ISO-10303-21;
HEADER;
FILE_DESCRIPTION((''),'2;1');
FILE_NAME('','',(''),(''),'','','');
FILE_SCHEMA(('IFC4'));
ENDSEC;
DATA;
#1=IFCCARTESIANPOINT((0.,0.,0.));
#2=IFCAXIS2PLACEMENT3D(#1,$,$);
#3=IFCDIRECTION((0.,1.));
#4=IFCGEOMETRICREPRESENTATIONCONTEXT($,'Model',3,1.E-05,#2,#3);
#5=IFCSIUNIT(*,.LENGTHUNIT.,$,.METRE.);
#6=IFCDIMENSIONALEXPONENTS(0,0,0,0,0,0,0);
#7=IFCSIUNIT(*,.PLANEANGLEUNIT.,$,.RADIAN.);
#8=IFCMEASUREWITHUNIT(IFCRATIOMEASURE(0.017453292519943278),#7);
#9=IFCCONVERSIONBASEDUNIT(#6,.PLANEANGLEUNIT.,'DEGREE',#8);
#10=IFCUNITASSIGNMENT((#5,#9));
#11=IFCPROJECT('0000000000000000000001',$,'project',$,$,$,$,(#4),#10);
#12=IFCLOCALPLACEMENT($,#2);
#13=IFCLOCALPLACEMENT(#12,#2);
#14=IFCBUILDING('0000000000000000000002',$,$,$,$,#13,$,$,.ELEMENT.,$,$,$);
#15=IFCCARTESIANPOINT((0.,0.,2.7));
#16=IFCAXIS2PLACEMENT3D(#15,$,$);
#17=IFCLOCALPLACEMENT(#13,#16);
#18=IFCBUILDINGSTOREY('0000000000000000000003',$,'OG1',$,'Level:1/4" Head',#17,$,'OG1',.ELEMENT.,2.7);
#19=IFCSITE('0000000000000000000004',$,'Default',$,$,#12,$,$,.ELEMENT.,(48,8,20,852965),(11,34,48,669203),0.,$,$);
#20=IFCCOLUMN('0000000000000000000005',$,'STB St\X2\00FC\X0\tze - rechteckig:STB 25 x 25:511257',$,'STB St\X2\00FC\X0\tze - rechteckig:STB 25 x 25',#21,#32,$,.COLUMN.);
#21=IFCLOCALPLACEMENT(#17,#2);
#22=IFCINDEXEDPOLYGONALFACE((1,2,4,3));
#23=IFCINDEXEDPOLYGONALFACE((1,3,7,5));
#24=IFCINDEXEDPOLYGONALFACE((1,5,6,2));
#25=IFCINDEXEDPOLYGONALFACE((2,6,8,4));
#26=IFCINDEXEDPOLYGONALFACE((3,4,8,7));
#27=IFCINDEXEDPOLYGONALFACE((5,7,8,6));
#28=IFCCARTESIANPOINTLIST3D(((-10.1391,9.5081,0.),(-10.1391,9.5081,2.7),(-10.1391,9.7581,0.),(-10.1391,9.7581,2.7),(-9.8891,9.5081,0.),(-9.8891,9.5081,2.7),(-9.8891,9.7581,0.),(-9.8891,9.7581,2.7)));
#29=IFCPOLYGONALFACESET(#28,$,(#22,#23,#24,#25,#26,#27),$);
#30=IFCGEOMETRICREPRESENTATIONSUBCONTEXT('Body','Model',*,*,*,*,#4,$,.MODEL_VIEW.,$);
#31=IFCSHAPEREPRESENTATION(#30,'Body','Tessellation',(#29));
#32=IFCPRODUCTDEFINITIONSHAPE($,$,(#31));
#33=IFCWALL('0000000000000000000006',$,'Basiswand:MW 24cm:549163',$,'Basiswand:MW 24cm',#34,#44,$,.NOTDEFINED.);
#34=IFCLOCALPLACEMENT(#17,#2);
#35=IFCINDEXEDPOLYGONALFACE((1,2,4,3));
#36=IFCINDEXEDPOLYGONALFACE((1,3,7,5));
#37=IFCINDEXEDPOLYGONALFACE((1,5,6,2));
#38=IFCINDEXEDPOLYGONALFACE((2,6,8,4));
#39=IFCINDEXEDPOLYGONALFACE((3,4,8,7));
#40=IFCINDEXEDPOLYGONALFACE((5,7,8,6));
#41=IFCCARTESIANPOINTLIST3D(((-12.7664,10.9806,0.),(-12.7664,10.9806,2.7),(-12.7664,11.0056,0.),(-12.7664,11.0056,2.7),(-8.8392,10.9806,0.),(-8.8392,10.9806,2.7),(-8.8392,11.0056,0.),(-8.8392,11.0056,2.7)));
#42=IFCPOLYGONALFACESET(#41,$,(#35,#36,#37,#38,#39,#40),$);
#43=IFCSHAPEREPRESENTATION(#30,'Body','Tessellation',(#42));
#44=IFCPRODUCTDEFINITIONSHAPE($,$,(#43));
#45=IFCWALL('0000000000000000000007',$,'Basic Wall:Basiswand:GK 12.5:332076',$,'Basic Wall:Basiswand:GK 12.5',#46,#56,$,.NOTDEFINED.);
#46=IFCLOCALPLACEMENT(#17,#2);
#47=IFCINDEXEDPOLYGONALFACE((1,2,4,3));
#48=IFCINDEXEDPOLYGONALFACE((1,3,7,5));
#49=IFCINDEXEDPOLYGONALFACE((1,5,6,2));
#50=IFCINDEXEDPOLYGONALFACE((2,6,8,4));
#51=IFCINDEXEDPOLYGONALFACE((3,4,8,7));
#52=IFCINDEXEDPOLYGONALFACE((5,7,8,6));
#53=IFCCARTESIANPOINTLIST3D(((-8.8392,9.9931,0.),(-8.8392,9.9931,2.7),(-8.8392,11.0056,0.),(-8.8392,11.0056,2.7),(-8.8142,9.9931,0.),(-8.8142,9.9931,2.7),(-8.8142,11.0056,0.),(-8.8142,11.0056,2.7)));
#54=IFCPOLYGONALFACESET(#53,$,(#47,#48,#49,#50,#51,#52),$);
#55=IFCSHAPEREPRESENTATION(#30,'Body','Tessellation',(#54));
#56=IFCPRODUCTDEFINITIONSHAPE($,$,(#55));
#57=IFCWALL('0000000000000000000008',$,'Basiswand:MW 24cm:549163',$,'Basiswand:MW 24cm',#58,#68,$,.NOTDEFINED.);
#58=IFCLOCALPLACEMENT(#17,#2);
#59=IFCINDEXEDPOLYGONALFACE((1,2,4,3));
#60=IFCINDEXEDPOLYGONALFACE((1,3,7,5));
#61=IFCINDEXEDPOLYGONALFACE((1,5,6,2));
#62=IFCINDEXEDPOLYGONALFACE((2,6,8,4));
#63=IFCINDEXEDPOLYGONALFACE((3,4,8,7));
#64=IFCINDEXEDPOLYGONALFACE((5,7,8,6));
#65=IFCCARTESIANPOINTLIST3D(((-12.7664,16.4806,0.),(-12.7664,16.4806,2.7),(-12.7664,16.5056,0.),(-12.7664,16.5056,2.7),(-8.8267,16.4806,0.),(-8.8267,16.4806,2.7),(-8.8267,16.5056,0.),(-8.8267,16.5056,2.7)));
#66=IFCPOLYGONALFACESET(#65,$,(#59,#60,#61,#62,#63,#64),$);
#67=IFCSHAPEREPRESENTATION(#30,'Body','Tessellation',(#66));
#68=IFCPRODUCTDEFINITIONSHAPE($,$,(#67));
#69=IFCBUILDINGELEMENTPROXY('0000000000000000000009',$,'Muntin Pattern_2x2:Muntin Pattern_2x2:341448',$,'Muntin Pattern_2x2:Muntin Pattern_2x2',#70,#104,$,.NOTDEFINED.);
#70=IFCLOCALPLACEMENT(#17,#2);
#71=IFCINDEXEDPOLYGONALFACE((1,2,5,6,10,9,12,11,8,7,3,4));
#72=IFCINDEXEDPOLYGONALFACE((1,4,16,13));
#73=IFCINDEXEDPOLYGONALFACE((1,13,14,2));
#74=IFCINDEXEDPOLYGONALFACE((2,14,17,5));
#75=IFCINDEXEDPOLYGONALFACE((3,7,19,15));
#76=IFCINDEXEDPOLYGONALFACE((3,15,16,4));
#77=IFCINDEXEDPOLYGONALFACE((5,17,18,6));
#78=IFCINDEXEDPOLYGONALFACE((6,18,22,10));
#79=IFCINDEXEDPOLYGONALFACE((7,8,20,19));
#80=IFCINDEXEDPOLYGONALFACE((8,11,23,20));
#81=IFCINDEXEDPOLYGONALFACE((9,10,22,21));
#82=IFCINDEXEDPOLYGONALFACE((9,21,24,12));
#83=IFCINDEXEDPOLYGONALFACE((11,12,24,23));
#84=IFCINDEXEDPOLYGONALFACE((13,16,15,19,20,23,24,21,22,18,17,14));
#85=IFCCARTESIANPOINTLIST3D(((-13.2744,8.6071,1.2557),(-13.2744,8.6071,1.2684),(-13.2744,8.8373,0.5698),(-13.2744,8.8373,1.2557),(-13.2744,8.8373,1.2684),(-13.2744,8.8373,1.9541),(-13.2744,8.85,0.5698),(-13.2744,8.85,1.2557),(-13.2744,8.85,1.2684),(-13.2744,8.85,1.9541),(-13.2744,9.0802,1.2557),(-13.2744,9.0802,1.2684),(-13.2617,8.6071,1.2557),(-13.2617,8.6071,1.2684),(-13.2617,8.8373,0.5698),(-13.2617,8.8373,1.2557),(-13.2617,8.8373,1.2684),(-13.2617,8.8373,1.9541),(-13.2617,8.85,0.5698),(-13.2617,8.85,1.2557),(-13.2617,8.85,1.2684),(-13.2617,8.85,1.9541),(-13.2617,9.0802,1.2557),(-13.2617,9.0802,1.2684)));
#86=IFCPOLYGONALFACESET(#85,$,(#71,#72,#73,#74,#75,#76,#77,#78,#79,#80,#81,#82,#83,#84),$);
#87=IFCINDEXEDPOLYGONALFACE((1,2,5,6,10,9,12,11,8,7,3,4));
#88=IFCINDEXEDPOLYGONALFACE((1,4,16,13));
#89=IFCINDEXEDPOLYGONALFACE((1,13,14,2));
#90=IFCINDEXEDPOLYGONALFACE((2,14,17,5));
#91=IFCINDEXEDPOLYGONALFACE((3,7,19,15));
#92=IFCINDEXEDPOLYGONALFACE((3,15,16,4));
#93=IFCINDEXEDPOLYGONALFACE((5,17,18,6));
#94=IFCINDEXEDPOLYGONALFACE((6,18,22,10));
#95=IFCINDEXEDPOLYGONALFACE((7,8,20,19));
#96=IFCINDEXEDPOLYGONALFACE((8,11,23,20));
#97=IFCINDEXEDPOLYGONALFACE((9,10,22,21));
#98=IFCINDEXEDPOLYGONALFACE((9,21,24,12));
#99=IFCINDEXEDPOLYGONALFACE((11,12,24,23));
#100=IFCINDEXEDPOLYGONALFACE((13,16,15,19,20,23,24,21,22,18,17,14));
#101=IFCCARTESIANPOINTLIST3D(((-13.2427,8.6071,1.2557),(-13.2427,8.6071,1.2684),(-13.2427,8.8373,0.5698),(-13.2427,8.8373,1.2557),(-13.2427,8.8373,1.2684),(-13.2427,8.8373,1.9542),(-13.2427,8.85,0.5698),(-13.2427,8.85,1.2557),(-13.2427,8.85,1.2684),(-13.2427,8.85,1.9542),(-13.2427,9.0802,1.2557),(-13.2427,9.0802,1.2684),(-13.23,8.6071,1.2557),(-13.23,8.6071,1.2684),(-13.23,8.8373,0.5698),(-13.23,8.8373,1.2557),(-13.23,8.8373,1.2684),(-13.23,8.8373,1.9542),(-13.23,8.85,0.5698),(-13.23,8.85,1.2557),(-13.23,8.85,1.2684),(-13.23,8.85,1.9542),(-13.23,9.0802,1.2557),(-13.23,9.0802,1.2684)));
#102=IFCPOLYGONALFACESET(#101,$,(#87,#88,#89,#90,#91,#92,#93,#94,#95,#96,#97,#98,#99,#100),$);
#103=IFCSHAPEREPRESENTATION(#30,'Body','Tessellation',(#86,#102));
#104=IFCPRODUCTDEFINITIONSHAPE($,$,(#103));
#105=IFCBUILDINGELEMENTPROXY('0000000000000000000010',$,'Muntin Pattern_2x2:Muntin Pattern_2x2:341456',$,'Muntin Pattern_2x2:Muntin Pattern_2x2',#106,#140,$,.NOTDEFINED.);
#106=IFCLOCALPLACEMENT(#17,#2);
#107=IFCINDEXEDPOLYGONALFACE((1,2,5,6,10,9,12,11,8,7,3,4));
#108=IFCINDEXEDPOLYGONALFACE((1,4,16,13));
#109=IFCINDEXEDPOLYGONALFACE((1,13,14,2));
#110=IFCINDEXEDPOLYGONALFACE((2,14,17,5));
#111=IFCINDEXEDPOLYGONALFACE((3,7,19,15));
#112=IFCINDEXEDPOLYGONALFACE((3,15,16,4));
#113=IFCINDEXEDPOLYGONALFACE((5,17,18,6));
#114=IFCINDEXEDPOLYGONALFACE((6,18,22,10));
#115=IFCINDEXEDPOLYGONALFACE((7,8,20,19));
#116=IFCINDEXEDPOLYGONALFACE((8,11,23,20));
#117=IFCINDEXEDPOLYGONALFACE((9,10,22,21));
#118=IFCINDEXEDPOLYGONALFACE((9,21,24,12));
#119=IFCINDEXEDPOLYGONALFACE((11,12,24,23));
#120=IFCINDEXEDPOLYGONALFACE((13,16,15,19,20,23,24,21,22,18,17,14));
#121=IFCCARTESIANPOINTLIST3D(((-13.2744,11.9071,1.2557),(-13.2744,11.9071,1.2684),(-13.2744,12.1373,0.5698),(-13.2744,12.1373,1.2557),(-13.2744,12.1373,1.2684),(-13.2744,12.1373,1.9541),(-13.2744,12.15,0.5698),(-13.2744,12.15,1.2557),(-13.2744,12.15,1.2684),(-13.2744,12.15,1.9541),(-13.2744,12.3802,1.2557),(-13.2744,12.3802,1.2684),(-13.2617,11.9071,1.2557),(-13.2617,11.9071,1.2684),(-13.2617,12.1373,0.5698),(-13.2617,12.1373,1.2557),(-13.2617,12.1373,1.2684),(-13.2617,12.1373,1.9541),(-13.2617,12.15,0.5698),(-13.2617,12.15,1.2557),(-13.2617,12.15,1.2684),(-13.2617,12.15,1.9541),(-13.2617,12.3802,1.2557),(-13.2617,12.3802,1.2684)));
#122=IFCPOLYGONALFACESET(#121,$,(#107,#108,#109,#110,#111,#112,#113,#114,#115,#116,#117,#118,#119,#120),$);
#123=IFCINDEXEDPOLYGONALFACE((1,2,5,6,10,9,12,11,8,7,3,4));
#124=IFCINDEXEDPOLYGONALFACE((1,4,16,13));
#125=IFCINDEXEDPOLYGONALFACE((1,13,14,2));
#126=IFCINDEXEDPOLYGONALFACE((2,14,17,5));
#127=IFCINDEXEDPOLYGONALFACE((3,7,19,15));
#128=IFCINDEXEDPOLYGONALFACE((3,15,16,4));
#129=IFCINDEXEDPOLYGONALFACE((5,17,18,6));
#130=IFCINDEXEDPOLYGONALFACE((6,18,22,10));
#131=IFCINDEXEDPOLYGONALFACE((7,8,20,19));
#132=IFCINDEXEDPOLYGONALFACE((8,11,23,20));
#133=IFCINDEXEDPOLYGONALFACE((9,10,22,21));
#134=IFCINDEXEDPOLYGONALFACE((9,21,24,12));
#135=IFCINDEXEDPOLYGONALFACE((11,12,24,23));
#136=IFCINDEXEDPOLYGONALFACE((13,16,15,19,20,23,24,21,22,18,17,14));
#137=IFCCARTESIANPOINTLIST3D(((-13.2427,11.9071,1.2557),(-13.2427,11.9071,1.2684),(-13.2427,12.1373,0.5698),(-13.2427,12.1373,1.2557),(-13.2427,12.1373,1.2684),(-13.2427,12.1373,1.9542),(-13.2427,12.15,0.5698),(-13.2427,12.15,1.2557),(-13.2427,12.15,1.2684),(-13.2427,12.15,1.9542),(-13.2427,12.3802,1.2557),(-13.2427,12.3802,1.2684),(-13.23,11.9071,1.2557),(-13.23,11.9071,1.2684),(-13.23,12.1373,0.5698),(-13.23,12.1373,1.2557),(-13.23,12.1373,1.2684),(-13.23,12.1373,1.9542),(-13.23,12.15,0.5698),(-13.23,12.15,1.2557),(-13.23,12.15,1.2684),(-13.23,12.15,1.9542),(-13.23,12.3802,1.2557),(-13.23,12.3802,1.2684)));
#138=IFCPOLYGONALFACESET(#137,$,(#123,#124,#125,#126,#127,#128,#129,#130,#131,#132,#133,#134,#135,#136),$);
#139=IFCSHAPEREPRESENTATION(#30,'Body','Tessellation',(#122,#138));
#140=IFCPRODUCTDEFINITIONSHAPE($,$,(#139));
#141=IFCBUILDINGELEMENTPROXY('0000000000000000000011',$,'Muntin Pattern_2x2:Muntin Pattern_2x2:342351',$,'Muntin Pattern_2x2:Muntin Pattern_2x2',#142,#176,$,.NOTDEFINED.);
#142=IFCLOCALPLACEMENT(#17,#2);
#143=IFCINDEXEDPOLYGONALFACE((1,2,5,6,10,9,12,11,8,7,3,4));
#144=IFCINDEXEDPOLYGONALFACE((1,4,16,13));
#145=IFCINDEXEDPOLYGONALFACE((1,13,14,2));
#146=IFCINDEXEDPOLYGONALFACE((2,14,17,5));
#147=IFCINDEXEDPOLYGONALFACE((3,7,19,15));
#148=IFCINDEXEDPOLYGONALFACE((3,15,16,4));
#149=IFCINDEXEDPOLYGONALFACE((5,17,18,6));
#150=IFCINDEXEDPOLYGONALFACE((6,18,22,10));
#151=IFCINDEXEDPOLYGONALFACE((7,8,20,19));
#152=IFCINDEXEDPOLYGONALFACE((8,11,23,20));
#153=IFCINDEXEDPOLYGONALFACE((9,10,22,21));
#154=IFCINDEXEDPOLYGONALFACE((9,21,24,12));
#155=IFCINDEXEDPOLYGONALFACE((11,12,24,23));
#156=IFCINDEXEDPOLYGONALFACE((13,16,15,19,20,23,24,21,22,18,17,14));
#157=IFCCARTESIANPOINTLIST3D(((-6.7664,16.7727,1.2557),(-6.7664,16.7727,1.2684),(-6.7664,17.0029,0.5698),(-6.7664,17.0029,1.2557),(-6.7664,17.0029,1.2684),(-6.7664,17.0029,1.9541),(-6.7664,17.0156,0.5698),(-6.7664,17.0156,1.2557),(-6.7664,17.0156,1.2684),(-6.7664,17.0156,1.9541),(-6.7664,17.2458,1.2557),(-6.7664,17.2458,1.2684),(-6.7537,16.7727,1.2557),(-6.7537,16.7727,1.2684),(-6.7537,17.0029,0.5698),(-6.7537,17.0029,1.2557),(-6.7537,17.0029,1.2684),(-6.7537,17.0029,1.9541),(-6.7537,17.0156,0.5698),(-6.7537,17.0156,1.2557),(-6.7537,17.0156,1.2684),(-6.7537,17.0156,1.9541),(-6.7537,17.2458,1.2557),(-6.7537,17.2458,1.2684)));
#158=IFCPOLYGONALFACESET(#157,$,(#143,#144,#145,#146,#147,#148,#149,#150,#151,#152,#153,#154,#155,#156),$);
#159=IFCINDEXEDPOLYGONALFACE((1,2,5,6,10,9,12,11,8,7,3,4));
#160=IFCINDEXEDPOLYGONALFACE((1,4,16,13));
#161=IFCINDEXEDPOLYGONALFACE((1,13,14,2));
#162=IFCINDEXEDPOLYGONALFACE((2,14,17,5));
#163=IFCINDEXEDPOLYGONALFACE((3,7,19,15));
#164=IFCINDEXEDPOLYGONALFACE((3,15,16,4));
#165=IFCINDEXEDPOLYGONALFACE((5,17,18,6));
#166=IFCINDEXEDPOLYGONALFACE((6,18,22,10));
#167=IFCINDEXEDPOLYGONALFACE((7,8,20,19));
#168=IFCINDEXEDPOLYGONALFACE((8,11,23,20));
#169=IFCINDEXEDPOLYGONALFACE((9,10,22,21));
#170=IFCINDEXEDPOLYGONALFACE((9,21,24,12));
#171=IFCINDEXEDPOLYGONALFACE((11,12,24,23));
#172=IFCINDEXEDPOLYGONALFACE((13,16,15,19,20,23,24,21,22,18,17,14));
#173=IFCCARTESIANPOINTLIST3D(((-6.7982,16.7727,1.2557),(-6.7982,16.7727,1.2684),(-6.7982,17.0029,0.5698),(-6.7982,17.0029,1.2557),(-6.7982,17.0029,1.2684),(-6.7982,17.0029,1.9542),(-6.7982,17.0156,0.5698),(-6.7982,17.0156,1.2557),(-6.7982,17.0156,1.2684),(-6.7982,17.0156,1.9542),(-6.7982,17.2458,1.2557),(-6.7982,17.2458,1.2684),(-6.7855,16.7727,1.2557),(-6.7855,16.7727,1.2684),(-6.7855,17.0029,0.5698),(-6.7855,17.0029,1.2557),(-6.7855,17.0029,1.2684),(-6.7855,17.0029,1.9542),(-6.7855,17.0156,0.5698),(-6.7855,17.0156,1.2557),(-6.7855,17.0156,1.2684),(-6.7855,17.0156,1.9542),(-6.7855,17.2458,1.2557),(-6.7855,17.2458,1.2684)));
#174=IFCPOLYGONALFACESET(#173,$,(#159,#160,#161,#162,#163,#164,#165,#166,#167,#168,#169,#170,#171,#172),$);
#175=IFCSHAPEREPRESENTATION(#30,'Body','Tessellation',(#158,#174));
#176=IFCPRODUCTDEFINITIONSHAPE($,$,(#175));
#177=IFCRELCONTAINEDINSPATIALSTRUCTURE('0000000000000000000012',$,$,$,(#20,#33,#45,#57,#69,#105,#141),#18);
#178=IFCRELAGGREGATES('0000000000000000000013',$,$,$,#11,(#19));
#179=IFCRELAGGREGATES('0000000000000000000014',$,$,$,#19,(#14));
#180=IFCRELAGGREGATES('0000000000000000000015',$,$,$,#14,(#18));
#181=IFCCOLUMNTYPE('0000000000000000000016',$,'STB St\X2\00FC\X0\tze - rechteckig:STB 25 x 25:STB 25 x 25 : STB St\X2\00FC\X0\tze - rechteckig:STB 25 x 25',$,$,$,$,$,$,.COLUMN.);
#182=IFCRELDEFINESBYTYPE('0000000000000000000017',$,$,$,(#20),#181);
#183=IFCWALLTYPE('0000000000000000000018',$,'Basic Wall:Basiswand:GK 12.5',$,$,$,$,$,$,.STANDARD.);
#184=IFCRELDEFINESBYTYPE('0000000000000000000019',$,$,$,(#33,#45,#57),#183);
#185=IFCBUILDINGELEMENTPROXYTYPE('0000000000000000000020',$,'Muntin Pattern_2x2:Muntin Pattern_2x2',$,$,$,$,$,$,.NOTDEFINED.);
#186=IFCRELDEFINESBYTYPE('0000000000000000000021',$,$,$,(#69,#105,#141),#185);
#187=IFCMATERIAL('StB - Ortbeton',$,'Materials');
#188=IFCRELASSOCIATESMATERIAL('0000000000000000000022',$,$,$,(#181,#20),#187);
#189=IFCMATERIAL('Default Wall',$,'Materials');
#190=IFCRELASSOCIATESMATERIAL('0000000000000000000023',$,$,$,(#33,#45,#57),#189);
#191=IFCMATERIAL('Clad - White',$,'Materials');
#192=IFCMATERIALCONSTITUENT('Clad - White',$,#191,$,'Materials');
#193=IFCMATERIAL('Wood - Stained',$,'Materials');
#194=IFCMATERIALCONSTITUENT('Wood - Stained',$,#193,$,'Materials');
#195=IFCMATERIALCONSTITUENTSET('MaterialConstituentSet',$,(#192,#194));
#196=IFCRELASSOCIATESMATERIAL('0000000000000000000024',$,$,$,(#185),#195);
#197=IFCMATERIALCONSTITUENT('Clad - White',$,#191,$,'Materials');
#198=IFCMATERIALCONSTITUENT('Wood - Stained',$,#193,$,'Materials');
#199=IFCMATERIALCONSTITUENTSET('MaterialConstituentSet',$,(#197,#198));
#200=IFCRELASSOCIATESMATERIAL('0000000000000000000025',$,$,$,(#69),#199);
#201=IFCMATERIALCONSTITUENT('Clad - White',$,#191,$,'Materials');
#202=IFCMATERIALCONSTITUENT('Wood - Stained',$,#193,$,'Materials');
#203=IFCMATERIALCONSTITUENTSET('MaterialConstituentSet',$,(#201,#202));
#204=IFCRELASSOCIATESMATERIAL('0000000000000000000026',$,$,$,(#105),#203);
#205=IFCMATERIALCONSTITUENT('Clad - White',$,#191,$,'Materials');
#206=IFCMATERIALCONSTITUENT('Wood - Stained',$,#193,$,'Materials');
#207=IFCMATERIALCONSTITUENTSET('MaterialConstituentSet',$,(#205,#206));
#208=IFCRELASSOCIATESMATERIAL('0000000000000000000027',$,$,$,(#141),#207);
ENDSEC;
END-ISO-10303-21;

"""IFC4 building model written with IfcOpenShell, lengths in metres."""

from ifc_helpers import new_model, entity, si_unit, converted_unit, direction, frame, origin, place, context, subcontext, project, spatial, indexed_curve, outline, extrude, source, transform, mapped, material, constituent, constituent_set, type_object, type_shapes, element, save


model = new_model("IFC4")

# Units and contexts
model_context = context("Model", 3, precision=1e-05, world=origin(), true_north=direction((0.0, 1.0)))
body_context = subcontext(model_context, "Body", "Model", "MODEL_VIEW")
ifc_project = project(units=[si_unit("LENGTHUNIT", "METRE"), converted_unit("PLANEANGLEUNIT", "DEGREE", entity("IfcRatioMeasure", 0.017453292519943278), si_unit("PLANEANGLEUNIT", "RADIAN"), dimensions=[0, 0, 0, 0, 0, 0, 0])], contexts=[model_context])

# Site, building, storey
site_placement = place(None, origin())
site = spatial("IfcSite", under=ifc_project, at=site_placement, Name="Default", CompositionType="ELEMENT", RefLatitude=(48, 8, 20, 852965), RefLongitude=(11, 34, 48, 669203), RefElevation=0.0)
building_placement = place(site_placement, origin())
building = spatial("IfcBuilding", under=site, at=building_placement, CompositionType="ELEMENT")
storey_placement = place(building_placement, frame((0.0, 0.0, 2.7)))
storey = spatial("IfcBuildingStorey", under=building, at=storey_placement, Name="OG1", ObjectType="Level:1/4\" Head", LongName="OG1", CompositionType="ELEMENT", Elevation=2.7)

# Column
ifc_material_1 = material(Name="StB - Ortbeton", Category="Materials")
column_type = type_object("IfcColumnType", Name="STB Stütze - rechteckig:STB 25 x 25:STB 25 x 25 : STB Stütze - rechteckig:STB 25 x 25", PredefinedType="COLUMN", material=ifc_material_1)
shared_shape_1 = source(origin(), body_context, "Body", "SweptSolid", [
    extrude(outline(indexed_curve([(-0.125, -0.125), (0.125, -0.125), (0.125, 0.125), (-0.125, 0.125), (-0.125, -0.125)], self_intersect=False)), frame((0.0, 0.0, 2.7), z_axis=(0.0, 0.0, 1.0), x_axis=(0.0, -1.0, 0.0)), (0.0, 0.0, 1.0), 2.7),
])
type_shapes(column_type, [shared_shape_1])
column_placement = place(storey_placement, frame((-10.0141, 9.6331, -2.7)))
element("IfcColumn", 1, at=column_placement, inside=storey, type_object=column_type, material=ifc_material_1, Name="STB Stütze - rechteckig:STB 25 x 25:511257", ObjectType="STB Stütze - rechteckig:STB 25 x 25", PredefinedType="COLUMN", context=body_context, shape_type="MappedRepresentation", body=[
    mapped(shared_shape_1, transform((0.0, 0.0, 0.0), scale=1.0)),
])

# Walls
ifc_material_2 = material(Name="Default Wall", Category="Materials")
wall_type = type_object("IfcWallType", Name="Basic Wall:Basiswand:GK 12.5", PredefinedType="STANDARD")
wall_1_placement = place(storey_placement, frame((-8.8392, 10.9931, 0.0), z_axis=(0.0, 0.0, 1.0), x_axis=(-1.0, 0.0, 0.0)))
element("IfcWall", 2, at=wall_1_placement, inside=storey, type_object=wall_type, material=ifc_material_2, Name="Basiswand:MW 24cm:549163", ObjectType="Basiswand:MW 24cm", PredefinedType="NOTDEFINED", context=body_context, shape_type="SweptSolid", body=[
    extrude(outline(indexed_curve([(3.9272, 0.0125), (0.0, 0.0125), (0.0, -0.0125), (3.9272, -0.0125), (3.9272, 0.0125)], self_intersect=False)), origin(), (0.0, 0.0, 1.0), 2.7),
])
wall_2_placement = place(storey_placement, frame((-8.8267, 11.0056, 0.0), z_axis=(0.0, 0.0, 1.0), x_axis=(0.0, -1.0, 0.0)))
element("IfcWall", 3, at=wall_2_placement, inside=storey, type_object=wall_type, material=ifc_material_2, Name="Basic Wall:Basiswand:GK 12.5:332076", ObjectType="Basic Wall:Basiswand:GK 12.5", PredefinedType="NOTDEFINED", context=body_context, shape_type="SweptSolid", body=[
    extrude(outline(indexed_curve([(1.0125, 0.0125), (0.0, 0.0125), (0.0, -0.0125), (1.0125, -0.0125), (1.0125, 0.0125)], self_intersect=False)), origin(), (0.0, 0.0, 1.0), 2.7),
])
wall_3_placement = place(storey_placement, frame((-8.8267, 16.4931, 0.0), z_axis=(0.0, 0.0, 1.0), x_axis=(-1.0, 0.0, 0.0)))
element("IfcWall", 4, at=wall_3_placement, inside=storey, type_object=wall_type, material=ifc_material_2, Name="Basiswand:MW 24cm:549163", ObjectType="Basiswand:MW 24cm", PredefinedType="NOTDEFINED", context=body_context, shape_type="SweptSolid", body=[
    extrude(outline(indexed_curve([(3.9397, 0.0125), (0.0, 0.0125), (0.0, -0.0125), (3.9397, -0.0125), (3.9397, 0.0125)], self_intersect=False)), origin(), (0.0, 0.0, 1.0), 2.7),
])

# Building element proxies
ifc_material_3 = material(Name="Clad - White", Category="Materials")
ifc_constituent_1 = constituent(ifc_material_3, Name="Clad - White", Category="Materials")
ifc_material_4 = material(Name="Wood - Stained", Category="Materials")
ifc_constituent_2 = constituent(ifc_material_4, Name="Wood - Stained", Category="Materials")
ifc_constituent_set_1 = constituent_set(constituents=[ifc_constituent_1, ifc_constituent_2], Name="MaterialConstituentSet")
ifc_constituent_3 = constituent(ifc_material_3, Name="Clad - White", Category="Materials")
ifc_constituent_4 = constituent(ifc_material_4, Name="Wood - Stained", Category="Materials")
ifc_constituent_set_2 = constituent_set(constituents=[ifc_constituent_3, ifc_constituent_4], Name="MaterialConstituentSet")
building_element_proxy_type_1 = type_object("IfcBuildingElementProxyType", Name="Muntin Pattern_2x2:Muntin Pattern_2x2", PredefinedType="NOTDEFINED", material=ifc_constituent_set_2)
shared_shape_2 = source(origin(), body_context, "Body", "SweptSolid", [
    extrude(outline(indexed_curve([(0.0064, -0.0064), (0.6921, -0.0064), (0.6921, 0.0063), (0.0064, 0.0063), (0.0064, 0.2365), (-0.0063, 0.2365), (-0.0063, 0.0063), (-0.6922, 0.0063), (-0.6922, -0.0064), (-0.0063, -0.0064), (-0.0063, -0.2365), (0.0064, -0.2365), (0.0064, -0.0064)], self_intersect=False)), frame((0.0, -0.0222, 0.6921), z_axis=(0.0, 1.0, 0.0), x_axis=(0.0, 0.0, 1.0)), (0.0, 0.0, 1.0), 0.0127),
    extrude(outline(indexed_curve([(0.0064, -0.0064), (0.6922, -0.0064), (0.6922, 0.0063), (0.0064, 0.0063), (0.0064, 0.2365), (-0.0063, 0.2365), (-0.0063, 0.0063), (-0.6922, 0.0063), (-0.6922, -0.0064), (-0.0063, -0.0064), (-0.0063, -0.2365), (0.0064, -0.2365), (0.0064, -0.0064)], self_intersect=False)), frame((0.0, 0.0095, 0.6922), z_axis=(0.0, 1.0, 0.0), x_axis=(0.0, 0.0, 1.0)), (0.0, 0.0, 1.0), 0.0127),
])
type_shapes(building_element_proxy_type_1, [shared_shape_2])
proxy_1_placement = place(storey_placement, frame((-13.2522, 8.8437, 0.5699), z_axis=(0.0, 0.0, 1.0), x_axis=(0.0, -1.0, 0.0)))
element("IfcBuildingElementProxy", 5, at=proxy_1_placement, inside=storey, type_object=building_element_proxy_type_1, material=ifc_constituent_set_1, Name="Muntin Pattern_2x2:Muntin Pattern_2x2:341448", ObjectType="Muntin Pattern_2x2:Muntin Pattern_2x2", PredefinedType="NOTDEFINED", context=body_context, shape_type="MappedRepresentation", body=[
    mapped(shared_shape_2, transform((0.0, 0.0, 0.0), scale=1.0)),
])
ifc_constituent_5 = constituent(ifc_material_3, Name="Clad - White", Category="Materials")
ifc_constituent_6 = constituent(ifc_material_4, Name="Wood - Stained", Category="Materials")
ifc_constituent_set_3 = constituent_set(constituents=[ifc_constituent_5, ifc_constituent_6], Name="MaterialConstituentSet")
proxy_2_placement = place(storey_placement, frame((-13.2522, 12.1437, 0.5699), z_axis=(0.0, 0.0, 1.0), x_axis=(0.0, -1.0, 0.0)))
element("IfcBuildingElementProxy", 6, at=proxy_2_placement, inside=storey, type_object=building_element_proxy_type_1, material=ifc_constituent_set_3, Name="Muntin Pattern_2x2:Muntin Pattern_2x2:341456", ObjectType="Muntin Pattern_2x2:Muntin Pattern_2x2", PredefinedType="NOTDEFINED", context=body_context, shape_type="MappedRepresentation", body=[
    mapped(shared_shape_2, transform((0.0, 0.0, 0.0), scale=1.0)),
])
ifc_constituent_7 = constituent(ifc_material_3, Name="Clad - White", Category="Materials")
ifc_constituent_8 = constituent(ifc_material_4, Name="Wood - Stained", Category="Materials")
ifc_constituent_set_4 = constituent_set(constituents=[ifc_constituent_7, ifc_constituent_8], Name="MaterialConstituentSet")
proxy_3_placement = place(storey_placement, frame((-6.7759, 17.0093, 0.5699), z_axis=(0.0, 0.0, 1.0), x_axis=(0.0, 1.0, 0.0)))
element("IfcBuildingElementProxy", 7, at=proxy_3_placement, inside=storey, type_object=building_element_proxy_type_1, material=ifc_constituent_set_4, Name="Muntin Pattern_2x2:Muntin Pattern_2x2:342351", ObjectType="Muntin Pattern_2x2:Muntin Pattern_2x2", PredefinedType="NOTDEFINED", context=body_context, shape_type="MappedRepresentation", body=[
    mapped(shared_shape_2, transform((0.0, 0.0, 0.0), scale=1.0)),
])

save(model, "model.ifc")
